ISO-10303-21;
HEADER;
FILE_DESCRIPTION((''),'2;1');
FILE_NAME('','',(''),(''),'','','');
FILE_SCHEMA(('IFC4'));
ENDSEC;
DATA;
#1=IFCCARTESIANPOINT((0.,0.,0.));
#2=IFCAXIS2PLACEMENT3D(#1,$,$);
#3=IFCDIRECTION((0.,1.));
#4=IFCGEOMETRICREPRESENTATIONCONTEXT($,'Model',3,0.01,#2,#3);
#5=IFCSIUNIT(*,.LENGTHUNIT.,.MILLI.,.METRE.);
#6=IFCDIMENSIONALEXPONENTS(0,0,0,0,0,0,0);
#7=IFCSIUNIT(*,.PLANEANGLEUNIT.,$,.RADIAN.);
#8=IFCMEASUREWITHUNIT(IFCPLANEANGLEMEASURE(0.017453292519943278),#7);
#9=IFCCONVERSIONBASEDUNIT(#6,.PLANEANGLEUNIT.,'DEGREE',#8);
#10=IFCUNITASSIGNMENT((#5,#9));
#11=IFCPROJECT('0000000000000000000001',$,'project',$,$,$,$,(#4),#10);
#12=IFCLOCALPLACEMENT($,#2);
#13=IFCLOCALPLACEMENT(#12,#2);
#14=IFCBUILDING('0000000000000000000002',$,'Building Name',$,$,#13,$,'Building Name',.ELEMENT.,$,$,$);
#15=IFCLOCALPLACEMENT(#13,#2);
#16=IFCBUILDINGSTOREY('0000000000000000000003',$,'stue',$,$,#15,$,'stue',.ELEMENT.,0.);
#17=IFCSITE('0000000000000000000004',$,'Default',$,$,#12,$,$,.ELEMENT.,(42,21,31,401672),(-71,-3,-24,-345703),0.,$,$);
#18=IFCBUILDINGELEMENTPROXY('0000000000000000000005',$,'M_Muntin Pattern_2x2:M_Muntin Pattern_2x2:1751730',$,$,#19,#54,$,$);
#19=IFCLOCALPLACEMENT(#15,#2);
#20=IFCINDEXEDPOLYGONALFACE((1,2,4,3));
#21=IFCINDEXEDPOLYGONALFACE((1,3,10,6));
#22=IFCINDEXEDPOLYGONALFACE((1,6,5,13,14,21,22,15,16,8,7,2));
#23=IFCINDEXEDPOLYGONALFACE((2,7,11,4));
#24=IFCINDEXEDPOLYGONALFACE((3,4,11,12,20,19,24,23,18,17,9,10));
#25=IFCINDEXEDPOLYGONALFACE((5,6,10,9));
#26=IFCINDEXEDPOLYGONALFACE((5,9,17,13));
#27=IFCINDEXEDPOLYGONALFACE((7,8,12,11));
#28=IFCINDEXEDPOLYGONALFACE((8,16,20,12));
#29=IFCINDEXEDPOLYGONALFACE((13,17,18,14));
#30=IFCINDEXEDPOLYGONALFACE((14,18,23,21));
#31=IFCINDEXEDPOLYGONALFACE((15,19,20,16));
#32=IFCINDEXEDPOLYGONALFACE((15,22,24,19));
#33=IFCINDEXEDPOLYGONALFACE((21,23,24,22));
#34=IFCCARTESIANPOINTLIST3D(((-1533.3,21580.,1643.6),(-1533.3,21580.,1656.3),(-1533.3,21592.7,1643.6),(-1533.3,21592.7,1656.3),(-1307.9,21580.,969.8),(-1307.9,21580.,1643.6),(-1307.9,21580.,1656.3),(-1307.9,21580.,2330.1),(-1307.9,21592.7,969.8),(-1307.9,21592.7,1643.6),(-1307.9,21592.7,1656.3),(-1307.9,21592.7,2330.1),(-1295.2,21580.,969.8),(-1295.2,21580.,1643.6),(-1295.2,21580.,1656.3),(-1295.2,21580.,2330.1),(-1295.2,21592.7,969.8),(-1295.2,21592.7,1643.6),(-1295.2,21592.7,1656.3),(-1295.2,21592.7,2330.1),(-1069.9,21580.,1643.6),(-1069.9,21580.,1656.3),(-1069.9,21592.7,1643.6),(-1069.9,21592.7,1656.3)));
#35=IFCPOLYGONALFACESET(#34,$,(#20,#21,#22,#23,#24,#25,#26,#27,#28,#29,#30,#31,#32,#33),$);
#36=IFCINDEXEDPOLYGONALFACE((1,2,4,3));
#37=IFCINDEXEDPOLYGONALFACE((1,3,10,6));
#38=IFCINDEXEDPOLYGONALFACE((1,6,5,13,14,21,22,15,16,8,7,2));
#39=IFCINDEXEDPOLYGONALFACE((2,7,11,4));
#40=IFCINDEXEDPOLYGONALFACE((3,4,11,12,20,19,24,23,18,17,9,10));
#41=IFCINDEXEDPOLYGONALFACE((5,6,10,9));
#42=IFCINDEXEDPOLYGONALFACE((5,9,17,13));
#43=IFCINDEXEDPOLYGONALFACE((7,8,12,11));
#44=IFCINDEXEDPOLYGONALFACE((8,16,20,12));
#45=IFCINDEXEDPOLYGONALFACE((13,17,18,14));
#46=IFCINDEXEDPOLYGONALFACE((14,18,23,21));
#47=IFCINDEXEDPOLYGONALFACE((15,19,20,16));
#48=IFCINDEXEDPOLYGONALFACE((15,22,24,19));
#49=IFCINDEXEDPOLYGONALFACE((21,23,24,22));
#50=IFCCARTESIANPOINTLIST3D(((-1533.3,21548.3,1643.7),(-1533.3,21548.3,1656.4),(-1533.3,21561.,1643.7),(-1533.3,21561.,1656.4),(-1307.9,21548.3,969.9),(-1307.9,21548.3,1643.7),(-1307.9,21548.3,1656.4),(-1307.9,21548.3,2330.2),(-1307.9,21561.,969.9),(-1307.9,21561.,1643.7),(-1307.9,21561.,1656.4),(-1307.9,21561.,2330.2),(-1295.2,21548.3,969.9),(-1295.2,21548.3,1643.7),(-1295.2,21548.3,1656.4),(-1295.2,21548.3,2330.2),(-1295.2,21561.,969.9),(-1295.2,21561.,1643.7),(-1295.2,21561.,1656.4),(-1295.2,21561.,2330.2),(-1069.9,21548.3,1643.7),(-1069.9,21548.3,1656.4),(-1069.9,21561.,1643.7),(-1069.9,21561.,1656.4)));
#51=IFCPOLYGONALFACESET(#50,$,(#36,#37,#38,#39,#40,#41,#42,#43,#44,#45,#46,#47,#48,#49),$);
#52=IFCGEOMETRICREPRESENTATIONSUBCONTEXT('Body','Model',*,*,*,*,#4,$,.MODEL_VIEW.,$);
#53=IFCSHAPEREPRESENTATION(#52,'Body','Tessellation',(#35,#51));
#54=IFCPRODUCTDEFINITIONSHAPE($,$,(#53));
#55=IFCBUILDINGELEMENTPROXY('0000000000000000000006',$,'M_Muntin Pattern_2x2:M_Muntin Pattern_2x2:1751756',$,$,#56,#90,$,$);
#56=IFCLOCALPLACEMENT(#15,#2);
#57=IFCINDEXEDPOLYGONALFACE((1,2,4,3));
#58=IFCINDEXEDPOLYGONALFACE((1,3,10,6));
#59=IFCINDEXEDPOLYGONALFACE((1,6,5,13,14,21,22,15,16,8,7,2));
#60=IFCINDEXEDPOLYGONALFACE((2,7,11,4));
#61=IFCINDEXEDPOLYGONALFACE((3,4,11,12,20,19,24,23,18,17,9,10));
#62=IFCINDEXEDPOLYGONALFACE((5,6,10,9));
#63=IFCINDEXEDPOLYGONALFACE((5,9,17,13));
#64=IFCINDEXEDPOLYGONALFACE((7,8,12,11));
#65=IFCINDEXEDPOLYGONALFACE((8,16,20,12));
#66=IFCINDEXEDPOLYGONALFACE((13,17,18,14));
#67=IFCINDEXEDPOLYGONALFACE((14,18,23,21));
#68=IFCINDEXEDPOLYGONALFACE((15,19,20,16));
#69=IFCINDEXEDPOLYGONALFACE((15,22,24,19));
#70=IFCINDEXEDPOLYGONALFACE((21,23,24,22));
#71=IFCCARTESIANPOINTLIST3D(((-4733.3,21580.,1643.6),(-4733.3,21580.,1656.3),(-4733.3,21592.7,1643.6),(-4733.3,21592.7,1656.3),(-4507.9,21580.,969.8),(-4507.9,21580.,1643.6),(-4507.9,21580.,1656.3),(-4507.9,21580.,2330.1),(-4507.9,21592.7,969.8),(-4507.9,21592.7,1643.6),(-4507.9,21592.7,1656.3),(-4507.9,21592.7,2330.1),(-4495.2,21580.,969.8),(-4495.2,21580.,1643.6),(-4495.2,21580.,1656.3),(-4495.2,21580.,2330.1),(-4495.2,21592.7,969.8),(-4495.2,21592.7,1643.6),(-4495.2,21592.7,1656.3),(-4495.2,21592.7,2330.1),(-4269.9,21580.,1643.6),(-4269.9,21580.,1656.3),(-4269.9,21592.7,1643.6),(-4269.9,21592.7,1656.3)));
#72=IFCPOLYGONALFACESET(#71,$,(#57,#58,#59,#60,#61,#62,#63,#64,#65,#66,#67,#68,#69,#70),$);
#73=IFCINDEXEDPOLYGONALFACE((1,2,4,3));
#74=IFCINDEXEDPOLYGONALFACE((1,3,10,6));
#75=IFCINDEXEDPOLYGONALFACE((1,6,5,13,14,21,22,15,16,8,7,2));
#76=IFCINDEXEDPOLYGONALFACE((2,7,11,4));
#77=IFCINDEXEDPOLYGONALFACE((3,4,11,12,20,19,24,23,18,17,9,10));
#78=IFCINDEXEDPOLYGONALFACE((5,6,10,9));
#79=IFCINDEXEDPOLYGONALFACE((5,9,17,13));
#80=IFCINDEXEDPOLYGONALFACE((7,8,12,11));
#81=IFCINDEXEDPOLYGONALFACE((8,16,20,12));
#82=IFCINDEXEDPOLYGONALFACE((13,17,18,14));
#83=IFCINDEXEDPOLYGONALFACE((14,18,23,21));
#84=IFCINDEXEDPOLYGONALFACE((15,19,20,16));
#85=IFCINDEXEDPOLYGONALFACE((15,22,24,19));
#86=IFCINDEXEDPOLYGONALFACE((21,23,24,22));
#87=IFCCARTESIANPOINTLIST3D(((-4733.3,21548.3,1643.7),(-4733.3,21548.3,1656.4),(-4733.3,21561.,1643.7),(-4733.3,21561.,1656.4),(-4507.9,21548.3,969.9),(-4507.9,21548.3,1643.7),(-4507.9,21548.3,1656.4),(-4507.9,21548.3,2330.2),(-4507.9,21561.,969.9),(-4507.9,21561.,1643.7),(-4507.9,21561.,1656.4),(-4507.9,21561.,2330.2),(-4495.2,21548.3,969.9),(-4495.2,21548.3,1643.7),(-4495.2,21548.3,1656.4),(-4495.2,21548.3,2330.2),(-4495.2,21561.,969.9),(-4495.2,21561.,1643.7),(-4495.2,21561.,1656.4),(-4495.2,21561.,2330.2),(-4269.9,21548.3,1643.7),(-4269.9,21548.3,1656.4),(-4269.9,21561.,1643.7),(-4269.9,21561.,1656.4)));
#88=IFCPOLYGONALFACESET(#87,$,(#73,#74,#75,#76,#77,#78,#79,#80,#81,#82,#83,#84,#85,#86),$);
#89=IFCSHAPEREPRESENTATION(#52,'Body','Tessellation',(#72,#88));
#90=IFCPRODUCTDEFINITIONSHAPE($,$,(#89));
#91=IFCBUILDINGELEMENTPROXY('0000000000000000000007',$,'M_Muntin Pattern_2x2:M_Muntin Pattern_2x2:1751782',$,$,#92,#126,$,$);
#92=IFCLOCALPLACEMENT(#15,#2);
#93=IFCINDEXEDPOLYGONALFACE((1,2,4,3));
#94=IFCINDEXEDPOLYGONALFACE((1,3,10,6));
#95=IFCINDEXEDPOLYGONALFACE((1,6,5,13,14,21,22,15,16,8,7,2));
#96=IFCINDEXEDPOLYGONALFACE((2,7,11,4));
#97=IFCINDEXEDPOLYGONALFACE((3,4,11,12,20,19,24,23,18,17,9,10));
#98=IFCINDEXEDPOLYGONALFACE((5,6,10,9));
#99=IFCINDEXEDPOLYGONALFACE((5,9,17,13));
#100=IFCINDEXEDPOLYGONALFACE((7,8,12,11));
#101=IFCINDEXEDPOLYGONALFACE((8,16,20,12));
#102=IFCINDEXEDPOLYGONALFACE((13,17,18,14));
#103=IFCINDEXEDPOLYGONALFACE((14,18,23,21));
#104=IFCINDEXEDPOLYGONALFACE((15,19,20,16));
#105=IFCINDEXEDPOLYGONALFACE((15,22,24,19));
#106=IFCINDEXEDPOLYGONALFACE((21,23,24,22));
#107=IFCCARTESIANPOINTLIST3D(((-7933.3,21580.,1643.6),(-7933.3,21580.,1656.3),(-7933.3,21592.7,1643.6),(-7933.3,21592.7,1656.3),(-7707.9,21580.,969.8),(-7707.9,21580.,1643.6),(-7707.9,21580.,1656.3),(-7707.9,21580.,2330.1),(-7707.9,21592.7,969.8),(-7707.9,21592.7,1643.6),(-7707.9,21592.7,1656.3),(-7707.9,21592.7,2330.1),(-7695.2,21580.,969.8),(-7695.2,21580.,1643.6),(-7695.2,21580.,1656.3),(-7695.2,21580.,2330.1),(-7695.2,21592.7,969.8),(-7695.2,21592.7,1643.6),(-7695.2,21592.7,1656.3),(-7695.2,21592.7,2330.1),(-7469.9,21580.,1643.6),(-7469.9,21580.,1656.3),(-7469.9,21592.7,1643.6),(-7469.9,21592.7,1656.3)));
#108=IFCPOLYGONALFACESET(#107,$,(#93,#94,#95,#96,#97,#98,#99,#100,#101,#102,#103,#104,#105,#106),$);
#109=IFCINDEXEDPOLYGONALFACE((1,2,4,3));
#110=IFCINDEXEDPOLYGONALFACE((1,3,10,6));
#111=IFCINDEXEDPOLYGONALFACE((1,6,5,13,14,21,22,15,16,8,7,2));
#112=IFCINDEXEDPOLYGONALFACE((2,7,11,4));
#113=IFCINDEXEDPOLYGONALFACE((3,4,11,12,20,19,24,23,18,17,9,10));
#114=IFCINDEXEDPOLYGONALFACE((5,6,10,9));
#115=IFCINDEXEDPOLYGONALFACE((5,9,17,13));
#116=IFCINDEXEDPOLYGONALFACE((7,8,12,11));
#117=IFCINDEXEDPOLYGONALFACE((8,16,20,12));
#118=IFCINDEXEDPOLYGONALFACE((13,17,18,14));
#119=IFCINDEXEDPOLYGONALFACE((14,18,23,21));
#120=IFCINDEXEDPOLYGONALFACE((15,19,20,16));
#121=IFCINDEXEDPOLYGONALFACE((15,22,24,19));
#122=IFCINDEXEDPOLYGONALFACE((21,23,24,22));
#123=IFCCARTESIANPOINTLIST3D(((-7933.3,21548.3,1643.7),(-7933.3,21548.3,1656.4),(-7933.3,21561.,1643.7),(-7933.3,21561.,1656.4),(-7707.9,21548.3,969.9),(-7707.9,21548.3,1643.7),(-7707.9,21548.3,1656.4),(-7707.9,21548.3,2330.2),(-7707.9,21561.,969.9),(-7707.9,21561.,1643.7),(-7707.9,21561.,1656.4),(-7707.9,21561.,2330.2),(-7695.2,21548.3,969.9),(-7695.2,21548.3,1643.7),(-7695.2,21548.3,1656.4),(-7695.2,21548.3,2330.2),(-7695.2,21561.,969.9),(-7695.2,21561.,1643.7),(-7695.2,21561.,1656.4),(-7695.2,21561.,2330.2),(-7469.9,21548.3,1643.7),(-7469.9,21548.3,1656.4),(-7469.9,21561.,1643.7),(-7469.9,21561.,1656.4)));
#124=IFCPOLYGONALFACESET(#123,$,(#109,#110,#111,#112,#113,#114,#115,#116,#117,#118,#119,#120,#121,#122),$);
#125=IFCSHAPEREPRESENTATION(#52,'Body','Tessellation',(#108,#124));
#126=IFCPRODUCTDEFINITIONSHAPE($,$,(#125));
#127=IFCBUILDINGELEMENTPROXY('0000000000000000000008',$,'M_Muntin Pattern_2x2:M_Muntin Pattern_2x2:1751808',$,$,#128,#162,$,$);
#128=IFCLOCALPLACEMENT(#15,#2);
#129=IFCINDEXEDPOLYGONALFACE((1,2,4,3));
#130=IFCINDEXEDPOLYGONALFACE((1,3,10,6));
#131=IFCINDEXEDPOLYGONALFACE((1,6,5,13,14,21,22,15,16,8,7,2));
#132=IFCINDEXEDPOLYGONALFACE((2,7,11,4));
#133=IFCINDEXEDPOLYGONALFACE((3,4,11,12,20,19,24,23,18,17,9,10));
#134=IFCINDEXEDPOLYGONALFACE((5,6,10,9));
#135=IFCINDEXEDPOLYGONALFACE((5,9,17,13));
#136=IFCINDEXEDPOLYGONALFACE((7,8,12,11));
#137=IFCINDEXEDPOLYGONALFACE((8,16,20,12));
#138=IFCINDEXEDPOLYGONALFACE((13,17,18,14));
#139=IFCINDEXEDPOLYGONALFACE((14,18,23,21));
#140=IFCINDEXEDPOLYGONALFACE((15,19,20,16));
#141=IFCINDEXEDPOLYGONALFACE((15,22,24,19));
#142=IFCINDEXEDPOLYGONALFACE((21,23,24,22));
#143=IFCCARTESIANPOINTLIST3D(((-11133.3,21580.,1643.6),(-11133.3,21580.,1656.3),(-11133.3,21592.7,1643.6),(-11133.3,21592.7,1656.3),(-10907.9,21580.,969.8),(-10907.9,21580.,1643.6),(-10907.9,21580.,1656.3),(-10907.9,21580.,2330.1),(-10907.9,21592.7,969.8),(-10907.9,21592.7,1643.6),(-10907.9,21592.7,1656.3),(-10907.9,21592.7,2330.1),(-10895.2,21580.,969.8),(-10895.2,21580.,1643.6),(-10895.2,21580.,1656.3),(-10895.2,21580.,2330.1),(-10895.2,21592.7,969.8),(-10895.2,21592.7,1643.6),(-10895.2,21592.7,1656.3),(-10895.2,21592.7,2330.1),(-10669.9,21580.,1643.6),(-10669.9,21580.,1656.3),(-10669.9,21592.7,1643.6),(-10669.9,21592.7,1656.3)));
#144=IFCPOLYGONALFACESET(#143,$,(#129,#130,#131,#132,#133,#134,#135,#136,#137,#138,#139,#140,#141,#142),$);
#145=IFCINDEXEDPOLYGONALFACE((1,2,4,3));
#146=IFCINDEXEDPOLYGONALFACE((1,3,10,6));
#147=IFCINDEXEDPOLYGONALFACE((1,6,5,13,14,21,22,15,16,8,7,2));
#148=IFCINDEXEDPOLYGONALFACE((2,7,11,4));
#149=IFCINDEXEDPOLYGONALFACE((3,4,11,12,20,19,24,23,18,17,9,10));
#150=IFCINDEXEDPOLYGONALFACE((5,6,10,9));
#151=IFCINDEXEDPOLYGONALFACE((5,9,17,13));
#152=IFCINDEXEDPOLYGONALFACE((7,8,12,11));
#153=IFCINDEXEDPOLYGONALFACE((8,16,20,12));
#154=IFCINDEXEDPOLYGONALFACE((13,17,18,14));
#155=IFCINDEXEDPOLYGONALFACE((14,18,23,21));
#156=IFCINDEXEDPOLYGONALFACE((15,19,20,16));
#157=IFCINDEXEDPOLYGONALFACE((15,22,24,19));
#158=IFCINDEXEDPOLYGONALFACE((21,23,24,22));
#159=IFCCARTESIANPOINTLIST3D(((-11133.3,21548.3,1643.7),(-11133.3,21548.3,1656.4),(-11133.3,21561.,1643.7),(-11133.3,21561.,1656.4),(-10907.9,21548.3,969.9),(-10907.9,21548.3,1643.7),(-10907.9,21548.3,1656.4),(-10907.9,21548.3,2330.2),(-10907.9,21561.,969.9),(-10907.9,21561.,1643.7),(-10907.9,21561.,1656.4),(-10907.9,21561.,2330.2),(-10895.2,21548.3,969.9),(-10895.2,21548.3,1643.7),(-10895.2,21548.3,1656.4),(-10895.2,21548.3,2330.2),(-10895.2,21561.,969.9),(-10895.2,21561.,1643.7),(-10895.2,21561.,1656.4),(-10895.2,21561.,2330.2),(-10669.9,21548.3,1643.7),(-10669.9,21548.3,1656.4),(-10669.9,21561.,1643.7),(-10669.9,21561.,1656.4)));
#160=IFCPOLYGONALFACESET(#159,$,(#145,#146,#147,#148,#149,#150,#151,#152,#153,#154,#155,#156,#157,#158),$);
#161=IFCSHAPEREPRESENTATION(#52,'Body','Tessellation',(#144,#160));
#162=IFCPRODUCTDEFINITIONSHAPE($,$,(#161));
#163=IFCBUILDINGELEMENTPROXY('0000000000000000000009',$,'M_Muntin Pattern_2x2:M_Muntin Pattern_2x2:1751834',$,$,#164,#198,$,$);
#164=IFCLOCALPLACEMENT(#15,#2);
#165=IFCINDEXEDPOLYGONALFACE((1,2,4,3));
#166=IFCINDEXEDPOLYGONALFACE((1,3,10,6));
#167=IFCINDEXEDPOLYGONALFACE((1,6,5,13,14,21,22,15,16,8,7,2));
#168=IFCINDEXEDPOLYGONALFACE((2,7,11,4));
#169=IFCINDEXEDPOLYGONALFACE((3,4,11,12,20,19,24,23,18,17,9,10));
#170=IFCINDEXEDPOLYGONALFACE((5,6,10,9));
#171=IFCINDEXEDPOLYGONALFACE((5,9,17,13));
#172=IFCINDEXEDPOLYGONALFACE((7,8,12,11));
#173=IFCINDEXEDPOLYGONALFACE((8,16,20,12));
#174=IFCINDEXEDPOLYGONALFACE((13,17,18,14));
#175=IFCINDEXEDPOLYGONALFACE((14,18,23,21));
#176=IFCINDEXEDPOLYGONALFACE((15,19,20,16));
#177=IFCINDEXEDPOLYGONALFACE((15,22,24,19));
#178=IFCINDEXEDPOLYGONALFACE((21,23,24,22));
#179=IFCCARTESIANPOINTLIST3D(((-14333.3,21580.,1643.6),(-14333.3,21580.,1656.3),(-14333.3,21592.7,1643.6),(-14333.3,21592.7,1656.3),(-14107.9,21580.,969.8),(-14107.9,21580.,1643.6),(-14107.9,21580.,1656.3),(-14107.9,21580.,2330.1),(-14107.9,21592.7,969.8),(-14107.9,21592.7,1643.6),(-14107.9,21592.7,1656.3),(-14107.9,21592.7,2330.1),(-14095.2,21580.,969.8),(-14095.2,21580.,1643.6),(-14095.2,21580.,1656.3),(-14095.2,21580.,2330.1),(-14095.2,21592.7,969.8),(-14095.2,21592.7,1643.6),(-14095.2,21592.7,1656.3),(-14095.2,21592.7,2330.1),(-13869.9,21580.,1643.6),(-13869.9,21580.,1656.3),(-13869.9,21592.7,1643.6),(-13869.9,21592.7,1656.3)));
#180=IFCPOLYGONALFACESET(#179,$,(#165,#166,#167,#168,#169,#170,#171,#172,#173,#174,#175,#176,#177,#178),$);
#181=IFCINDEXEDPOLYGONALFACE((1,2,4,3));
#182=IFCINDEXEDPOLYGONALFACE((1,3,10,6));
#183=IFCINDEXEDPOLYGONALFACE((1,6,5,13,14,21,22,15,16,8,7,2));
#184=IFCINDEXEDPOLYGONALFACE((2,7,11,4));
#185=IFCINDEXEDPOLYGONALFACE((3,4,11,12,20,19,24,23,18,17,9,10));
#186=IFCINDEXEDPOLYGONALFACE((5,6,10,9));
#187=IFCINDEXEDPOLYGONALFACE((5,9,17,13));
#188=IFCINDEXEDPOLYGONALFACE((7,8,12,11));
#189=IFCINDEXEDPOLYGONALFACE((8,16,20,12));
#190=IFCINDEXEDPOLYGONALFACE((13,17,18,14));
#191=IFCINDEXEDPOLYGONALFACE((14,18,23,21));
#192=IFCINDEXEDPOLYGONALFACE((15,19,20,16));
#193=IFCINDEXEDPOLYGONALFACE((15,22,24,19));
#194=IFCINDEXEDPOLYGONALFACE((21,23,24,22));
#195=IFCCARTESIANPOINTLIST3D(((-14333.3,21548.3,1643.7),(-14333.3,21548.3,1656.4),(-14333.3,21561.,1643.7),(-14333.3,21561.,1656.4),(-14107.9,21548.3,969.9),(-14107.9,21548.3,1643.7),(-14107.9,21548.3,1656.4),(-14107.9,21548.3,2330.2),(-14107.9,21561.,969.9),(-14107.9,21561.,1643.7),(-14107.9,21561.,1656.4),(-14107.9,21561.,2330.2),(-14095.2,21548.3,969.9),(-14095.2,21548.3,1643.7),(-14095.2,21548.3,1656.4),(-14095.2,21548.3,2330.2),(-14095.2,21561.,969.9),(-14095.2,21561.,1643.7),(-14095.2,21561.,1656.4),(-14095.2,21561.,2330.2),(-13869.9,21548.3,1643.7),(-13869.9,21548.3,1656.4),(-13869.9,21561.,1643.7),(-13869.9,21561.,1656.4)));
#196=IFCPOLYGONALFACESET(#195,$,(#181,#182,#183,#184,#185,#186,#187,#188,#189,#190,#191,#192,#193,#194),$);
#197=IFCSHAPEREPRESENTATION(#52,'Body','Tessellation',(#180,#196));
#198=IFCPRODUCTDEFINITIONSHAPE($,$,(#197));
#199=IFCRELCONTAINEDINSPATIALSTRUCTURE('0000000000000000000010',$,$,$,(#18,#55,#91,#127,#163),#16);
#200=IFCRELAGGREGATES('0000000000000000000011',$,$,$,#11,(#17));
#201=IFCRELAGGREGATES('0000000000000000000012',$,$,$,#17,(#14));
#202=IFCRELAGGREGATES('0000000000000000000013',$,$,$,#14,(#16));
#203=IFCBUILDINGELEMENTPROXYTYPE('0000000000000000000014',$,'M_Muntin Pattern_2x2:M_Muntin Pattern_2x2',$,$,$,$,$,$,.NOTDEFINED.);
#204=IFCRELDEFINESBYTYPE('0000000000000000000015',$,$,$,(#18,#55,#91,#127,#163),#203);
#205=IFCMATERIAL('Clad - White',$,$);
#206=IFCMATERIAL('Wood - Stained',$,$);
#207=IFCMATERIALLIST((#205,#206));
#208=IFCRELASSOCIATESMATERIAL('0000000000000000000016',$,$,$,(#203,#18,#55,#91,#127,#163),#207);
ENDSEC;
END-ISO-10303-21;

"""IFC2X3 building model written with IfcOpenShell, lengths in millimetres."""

from ifc_helpers import new_model, entity, si_unit, converted_unit, direction, frame, origin, place, context, subcontext, project, spatial, polyline, outline, extrude, source, transform, mapped, material, material_list, type_object, type_shapes, element, save


model = new_model("IFC2X3")

# Units and contexts
model_context = context("Model", 3, precision=0.01, world=origin(), true_north=direction((0.0, 1.0)))
body_context = subcontext(model_context, "Body", "Model", "MODEL_VIEW")
ifc_project = project(units=[si_unit("LENGTHUNIT", "METRE", prefix="MILLI"), converted_unit("PLANEANGLEUNIT", "DEGREE", entity("IfcPlaneAngleMeasure", 0.017453292519943278), si_unit("PLANEANGLEUNIT", "RADIAN"), dimensions=[0, 0, 0, 0, 0, 0, 0])], contexts=[model_context])

# Site, building, storey
site_placement = place(None, origin())
site = spatial("IfcSite", under=ifc_project, at=site_placement, Name="Default", CompositionType="ELEMENT", RefLatitude=(42, 21, 31, 401672), RefLongitude=(-71, -3, -24, -345703), RefElevation=0.0)
building_placement = place(site_placement, origin())
building = spatial("IfcBuilding", under=site, at=building_placement, Name="Building Name", LongName="Building Name", CompositionType="ELEMENT")
storey_placement = place(building_placement, origin())
storey = spatial("IfcBuildingStorey", under=building, at=storey_placement, Name="stue", LongName="stue", CompositionType="ELEMENT", Elevation=0.0)

# Building element proxies
ifc_material_1 = material(Name="Clad - White")
ifc_material_2 = material(Name="Wood - Stained")
ifc_material_list = material_list([ifc_material_1, ifc_material_2])
building_element_proxy_type_1 = type_object("IfcBuildingElementProxyType", Name="M_Muntin Pattern_2x2:M_Muntin Pattern_2x2", PredefinedType="NOTDEFINED", material=ifc_material_list)
shared_shape_1 = source(origin(), body_context, "Body", "SweptSolid", [
    extrude(outline(polyline([(6.4, -6.4), (680.1, -6.4), (680.1, 6.3), (6.4, 6.3), (6.4, 231.7), (-6.3, 231.7), (-6.3, 6.3), (-680.2, 6.3), (-680.2, -6.4), (-6.3, -6.4), (-6.3, -231.7), (6.4, -231.7), (6.4, -6.4)])), frame((0.0, -22.2, 680.1), z_axis=(0.0, 1.0, 0.0), x_axis=(0.0, 0.0, 1.0)), (0.0, 0.0, 1.0), 12.7),
    extrude(outline(polyline([(6.4, -6.4), (680.2, -6.4), (680.2, 6.3), (6.4, 6.3), (6.4, 231.7), (-6.3, 231.7), (-6.3, 6.3), (-680.2, 6.3), (-680.2, -6.4), (-6.3, -6.4), (-6.3, -231.7), (6.4, -231.7), (6.4, -6.4)])), frame((0.0, 9.5, 680.2), z_axis=(0.0, 1.0, 0.0), x_axis=(0.0, 0.0, 1.0)), (0.0, 0.0, 1.0), 12.7),
])
type_shapes(building_element_proxy_type_1, [shared_shape_1])
for number, where, z_axis, x_axis, name in (
    (1, (-1301.6, 21570.5, 969.9), (0.0, 0.0, 1.0), (-1.0, 0.0, 0.0), "M_Muntin Pattern_2x2:M_Muntin Pattern_2x2:1751730"),
    (2, (-4501.6, 21570.5, 969.9), (0.0, 0.0, 1.0), (-1.0, 0.0, 0.0), "M_Muntin Pattern_2x2:M_Muntin Pattern_2x2:1751756"),
    (3, (-7701.6, 21570.5, 969.9), (0.0, 0.0, 1.0), (-1.0, 0.0, 0.0), "M_Muntin Pattern_2x2:M_Muntin Pattern_2x2:1751782"),
    (4, (-10901.6, 21570.5, 969.9), (0.0, 0.0, 1.0), (-1.0, 0.0, 0.0), "M_Muntin Pattern_2x2:M_Muntin Pattern_2x2:1751808"),
    (5, (-14101.6, 21570.5, 969.9), (0.0, 0.0, 1.0), (-1.0, 0.0, 0.0), "M_Muntin Pattern_2x2:M_Muntin Pattern_2x2:1751834"),
):
    element("IfcBuildingElementProxy", number, at=place(storey_placement, frame(where, z_axis=z_axis, x_axis=x_axis)), inside=storey, type_object=building_element_proxy_type_1, material=ifc_material_list, Name=name, context=body_context, shape_type="MappedRepresentation", body=[
        mapped(shared_shape_1, transform((0.0, 0.0, 0.0), scale=1.0)),
    ])

save(model, "model.ifc")
